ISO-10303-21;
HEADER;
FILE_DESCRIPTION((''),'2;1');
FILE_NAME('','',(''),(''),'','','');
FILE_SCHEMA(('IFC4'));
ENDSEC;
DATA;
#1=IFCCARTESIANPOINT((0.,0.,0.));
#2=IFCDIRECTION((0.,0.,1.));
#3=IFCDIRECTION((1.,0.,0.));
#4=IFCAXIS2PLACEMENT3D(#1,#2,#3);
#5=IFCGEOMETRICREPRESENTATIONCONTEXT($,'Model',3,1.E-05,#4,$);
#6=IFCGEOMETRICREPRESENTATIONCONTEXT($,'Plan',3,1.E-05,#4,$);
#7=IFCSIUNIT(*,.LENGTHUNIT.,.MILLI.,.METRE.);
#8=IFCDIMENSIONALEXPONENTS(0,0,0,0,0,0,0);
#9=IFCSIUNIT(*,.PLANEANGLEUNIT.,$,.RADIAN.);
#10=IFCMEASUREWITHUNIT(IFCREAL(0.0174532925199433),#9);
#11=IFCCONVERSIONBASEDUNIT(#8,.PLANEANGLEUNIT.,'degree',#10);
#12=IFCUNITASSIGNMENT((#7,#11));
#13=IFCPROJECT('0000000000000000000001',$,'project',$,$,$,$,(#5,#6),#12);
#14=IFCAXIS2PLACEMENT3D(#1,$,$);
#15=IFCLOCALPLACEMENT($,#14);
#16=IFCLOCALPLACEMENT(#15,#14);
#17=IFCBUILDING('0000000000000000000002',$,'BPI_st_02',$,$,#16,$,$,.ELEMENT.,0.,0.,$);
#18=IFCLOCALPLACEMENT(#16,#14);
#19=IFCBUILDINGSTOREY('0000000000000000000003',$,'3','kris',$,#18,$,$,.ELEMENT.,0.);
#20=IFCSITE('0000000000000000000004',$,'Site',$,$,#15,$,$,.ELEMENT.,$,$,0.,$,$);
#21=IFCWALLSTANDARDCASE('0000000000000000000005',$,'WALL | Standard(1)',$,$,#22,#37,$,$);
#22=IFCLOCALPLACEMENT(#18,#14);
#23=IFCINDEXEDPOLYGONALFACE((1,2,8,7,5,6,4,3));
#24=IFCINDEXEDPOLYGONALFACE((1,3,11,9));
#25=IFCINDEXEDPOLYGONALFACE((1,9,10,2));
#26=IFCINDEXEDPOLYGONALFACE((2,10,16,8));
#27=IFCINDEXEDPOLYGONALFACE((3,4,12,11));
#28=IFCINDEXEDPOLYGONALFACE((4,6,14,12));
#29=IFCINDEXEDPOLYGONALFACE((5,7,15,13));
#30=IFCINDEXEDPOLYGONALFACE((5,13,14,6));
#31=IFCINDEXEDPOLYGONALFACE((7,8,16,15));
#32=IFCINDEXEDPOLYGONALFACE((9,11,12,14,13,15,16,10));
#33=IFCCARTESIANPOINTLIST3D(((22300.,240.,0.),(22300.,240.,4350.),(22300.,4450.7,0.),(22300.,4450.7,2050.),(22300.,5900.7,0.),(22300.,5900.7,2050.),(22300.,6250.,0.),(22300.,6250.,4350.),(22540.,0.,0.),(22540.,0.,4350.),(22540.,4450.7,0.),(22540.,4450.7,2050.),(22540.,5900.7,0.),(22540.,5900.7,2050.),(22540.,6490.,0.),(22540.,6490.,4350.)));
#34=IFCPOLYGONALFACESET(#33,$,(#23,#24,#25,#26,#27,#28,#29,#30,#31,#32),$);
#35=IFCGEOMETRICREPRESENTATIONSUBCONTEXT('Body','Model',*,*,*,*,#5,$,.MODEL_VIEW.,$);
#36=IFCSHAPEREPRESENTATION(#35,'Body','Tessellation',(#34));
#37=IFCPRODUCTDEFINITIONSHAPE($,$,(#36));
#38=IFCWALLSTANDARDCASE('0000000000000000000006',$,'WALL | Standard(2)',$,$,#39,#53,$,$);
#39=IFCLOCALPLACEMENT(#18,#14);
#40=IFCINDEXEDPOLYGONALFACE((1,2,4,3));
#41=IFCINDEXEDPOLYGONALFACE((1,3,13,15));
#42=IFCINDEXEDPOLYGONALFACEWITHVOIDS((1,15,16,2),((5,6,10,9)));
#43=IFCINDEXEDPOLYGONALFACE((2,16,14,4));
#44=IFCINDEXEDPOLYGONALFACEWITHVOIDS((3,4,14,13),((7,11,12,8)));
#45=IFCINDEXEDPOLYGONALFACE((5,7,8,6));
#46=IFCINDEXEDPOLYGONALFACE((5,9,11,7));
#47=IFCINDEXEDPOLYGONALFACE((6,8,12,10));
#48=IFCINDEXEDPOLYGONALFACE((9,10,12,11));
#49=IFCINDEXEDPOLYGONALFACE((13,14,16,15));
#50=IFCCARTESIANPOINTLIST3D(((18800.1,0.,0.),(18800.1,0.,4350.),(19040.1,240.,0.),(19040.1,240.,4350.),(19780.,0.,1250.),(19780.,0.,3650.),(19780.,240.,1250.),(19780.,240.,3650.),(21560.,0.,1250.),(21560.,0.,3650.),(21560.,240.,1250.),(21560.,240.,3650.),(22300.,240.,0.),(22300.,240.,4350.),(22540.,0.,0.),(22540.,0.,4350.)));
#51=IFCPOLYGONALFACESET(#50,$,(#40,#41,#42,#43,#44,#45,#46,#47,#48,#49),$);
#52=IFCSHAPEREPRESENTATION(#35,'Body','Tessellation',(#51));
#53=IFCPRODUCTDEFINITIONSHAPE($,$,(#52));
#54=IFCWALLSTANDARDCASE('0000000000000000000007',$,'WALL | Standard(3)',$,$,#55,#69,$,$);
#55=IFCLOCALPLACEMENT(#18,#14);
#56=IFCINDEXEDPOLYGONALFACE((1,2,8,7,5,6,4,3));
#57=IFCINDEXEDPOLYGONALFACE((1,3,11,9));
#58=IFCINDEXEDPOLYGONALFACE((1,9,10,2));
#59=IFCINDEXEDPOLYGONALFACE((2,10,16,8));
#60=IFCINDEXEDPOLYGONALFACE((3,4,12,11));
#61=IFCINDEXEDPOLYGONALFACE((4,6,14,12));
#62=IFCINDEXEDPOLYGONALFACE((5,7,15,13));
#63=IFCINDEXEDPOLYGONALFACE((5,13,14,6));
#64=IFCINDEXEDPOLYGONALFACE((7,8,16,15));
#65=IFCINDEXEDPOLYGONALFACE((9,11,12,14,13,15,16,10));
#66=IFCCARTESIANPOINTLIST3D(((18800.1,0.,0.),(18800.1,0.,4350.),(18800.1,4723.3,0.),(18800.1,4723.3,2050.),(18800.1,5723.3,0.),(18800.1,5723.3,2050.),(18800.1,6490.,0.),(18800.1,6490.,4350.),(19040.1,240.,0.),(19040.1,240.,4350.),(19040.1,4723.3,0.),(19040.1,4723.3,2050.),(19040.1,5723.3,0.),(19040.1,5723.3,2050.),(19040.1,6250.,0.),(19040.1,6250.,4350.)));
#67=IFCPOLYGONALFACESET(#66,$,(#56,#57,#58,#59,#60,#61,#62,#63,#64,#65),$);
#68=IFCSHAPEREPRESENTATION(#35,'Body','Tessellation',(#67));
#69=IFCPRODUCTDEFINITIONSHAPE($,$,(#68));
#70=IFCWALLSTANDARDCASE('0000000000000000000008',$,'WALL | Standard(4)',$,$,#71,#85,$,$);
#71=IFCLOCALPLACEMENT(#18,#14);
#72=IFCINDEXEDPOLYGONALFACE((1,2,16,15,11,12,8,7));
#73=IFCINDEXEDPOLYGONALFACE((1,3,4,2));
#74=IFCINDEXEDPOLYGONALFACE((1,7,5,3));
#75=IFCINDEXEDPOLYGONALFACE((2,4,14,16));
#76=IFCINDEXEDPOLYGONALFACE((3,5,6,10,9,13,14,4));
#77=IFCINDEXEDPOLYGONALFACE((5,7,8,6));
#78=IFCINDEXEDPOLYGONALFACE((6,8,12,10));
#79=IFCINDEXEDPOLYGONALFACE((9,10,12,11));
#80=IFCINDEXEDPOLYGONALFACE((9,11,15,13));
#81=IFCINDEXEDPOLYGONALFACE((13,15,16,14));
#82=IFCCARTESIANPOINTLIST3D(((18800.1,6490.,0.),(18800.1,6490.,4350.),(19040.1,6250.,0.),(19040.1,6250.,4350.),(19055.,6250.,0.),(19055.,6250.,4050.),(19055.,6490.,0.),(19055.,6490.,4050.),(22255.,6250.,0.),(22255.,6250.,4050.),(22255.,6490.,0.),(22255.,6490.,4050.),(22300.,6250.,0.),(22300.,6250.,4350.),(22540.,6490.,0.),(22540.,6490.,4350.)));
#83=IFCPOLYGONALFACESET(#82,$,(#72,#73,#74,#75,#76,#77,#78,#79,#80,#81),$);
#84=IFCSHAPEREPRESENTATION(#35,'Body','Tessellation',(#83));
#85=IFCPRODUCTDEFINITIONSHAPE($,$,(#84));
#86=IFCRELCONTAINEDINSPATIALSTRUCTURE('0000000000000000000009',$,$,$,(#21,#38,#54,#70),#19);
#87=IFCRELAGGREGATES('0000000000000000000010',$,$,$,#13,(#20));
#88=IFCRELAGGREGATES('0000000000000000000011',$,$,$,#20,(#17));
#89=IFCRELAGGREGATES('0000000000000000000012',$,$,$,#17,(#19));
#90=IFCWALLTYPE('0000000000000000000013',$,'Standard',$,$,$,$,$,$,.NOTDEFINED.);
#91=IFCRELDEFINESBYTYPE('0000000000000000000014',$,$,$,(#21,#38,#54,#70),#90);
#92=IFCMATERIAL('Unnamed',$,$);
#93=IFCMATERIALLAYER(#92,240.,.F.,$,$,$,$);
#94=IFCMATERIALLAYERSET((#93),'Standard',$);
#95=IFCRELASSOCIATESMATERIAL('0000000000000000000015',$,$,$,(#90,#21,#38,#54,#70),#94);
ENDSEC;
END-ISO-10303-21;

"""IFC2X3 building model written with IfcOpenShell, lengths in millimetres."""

from ifc_helpers import new_model, entity, si_unit, converted_unit, frame, origin, origin_with_axes, origin_2d_with_axis, place, context, subcontext, project, spatial, polyline, segment, composite_curve, rectangle, outline, extrude, material, layer, layer_set, layer_usage, type_object, element, save


model = new_model("IFC2X3")

# Units and contexts
model_context = context("Model", 3, precision=1e-05, world=origin_with_axes())
plan_context = context("Plan", 3, precision=1e-05, world=origin_with_axes())
body_context = subcontext(model_context, "Body", "Model", "MODEL_VIEW")
ifc_project = project(units=[si_unit("LENGTHUNIT", "METRE", prefix="MILLI"), converted_unit("PLANEANGLEUNIT", "degree", entity("IfcReal", 0.0174532925199433), si_unit("PLANEANGLEUNIT", "RADIAN"), dimensions=[0, 0, 0, 0, 0, 0, 0])], contexts=[model_context, plan_context])

# Site, building, storey
site_placement = place(None, origin())
site = spatial("IfcSite", under=ifc_project, at=site_placement, Name="Site", CompositionType="ELEMENT", RefElevation=0.0)
building_placement = place(site_placement, origin())
building = spatial("IfcBuilding", under=site, at=building_placement, Name="BPI_st_02", CompositionType="ELEMENT", ElevationOfRefHeight=0.0, ElevationOfTerrain=0.0)
storey_placement = place(building_placement, origin())
storey = spatial("IfcBuildingStorey", under=building, at=storey_placement, Name="3", Description="kris", CompositionType="ELEMENT", Elevation=0.0)

# Shared definitions
ifc_material = material(Name="Unnamed")

# Walls, openings
ifc_layer_1 = layer(ifc_material, 240.0, ventilated=False)
ifc_layer_set_1 = layer_set([ifc_layer_1], Name="Standard")
ifc_layer_usage_1 = layer_usage(ifc_layer_set_1, "AXIS2", "POSITIVE", -120.0)
wall_type = type_object("IfcWallType", Name="Standard", PredefinedType="NOTDEFINED", material=ifc_layer_set_1)
wall_1_placement = place(storey_placement, frame((22420.0, 6370.0, 0.0), z_axis=(0.0, 0.0, 1.0), x_axis=(0.0, -1.0, 0.0)))
wall_1 = element("IfcWallStandardCase", 1, at=wall_1_placement, inside=storey, type_object=wall_type, material=ifc_layer_usage_1, Name="WALL | Standard(1)", context=body_context, shape_type="SweptSolid", body=[
    extrude(outline(composite_curve([segment(polyline([(-120.0, 120.0), (120.0, -120.0)]), True, "CONTINUOUS"), segment(polyline([(120.0, -120.0), (6130.0, -120.0)]), True, "CONTINUOUS"), segment(polyline([(6130.0, -120.0), (6370.0, 120.0)]), True, "CONTINUOUS"), segment(polyline([(6370.0, 120.0), (-120.0, 120.0)]), True, "CONTINUOUS")], self_intersect=False)), origin(), (0.0, 0.0, 1.0), 4350.0),
])
opening_1_placement = place(wall_1_placement, frame((469.3, 0.0, 0.0)))
element("IfcOpeningElement", 2, at=opening_1_placement, cuts=wall_1, context=body_context, shape_type="SweptSolid", body=[
    extrude(rectangle(XDim=1450.0, YDim=2050.0, at=origin_2d_with_axis()), frame((725.0, 120.0, 1025.0), z_axis=(0.0, -1.0, 0.0), x_axis=(1.0, 0.0, 0.0)), (0.0, 0.0, 1.0), 240.0),
])
ifc_layer_usage_2 = layer_usage(ifc_layer_set_1, "AXIS2", "POSITIVE", -120.0)
wall_2_placement = place(storey_placement, frame((22420.0, 120.0, 0.0), z_axis=(0.0, 0.0, 1.0), x_axis=(-1.0, 0.0, 0.0)))
wall_2 = element("IfcWallStandardCase", 3, at=wall_2_placement, inside=storey, type_object=wall_type, material=ifc_layer_usage_2, Name="WALL | Standard(2)", context=body_context, shape_type="SweptSolid", body=[
    extrude(outline(composite_curve([segment(polyline([(-120.0, 120.0), (120.0, -120.0)]), True, "CONTINUOUS"), segment(polyline([(120.0, -120.0), (3380.0, -120.0)]), True, "CONTINUOUS"), segment(polyline([(3380.0, -120.0), (3620.0, 120.0)]), True, "CONTINUOUS"), segment(polyline([(3620.0, 120.0), (-120.0, 120.0)]), True, "CONTINUOUS")], self_intersect=False)), origin(), (0.0, 0.0, 1.0), 4350.0),
])
opening_2_placement = place(wall_2_placement, frame((860.0, 0.0, 1250.0)))
element("IfcOpeningElement", 4, at=opening_2_placement, cuts=wall_2, context=body_context, shape_type="SweptSolid", body=[
    extrude(rectangle(XDim=1780.0, YDim=2400.0, at=origin_2d_with_axis()), frame((890.0, 120.0, 1200.0), z_axis=(0.0, -1.0, 0.0), x_axis=(1.0, 0.0, 0.0)), (0.0, 0.0, 1.0), 240.0),
])
ifc_layer_usage_3 = layer_usage(ifc_layer_set_1, "AXIS2", "POSITIVE", -120.0)
wall_3_placement = place(storey_placement, frame((18920.1, 6370.0, 0.0), z_axis=(0.0, 0.0, 1.0), x_axis=(0.0, -1.0, 0.0)))
wall_3 = element("IfcWallStandardCase", 5, at=wall_3_placement, inside=storey, type_object=wall_type, material=ifc_layer_usage_3, Name="WALL | Standard(3)", context=body_context, shape_type="SweptSolid", body=[
    extrude(outline(composite_curve([segment(polyline([(120.0, 120.0), (-120.0, -120.0)]), True, "CONTINUOUS"), segment(polyline([(-120.0, -120.0), (6370.0, -120.0)]), True, "CONTINUOUS"), segment(polyline([(6370.0, -120.0), (6130.0, 120.0)]), True, "CONTINUOUS"), segment(polyline([(6130.0, 120.0), (120.0, 120.0)]), True, "CONTINUOUS")], self_intersect=False)), origin(), (0.0, 0.0, 1.0), 4350.0),
])
opening_3_placement = place(wall_3_placement, frame((646.6, 0.0, 0.0)))
element("IfcOpeningElement", 6, at=opening_3_placement, cuts=wall_3, context=body_context, shape_type="SweptSolid", body=[
    extrude(rectangle(XDim=1000.0, YDim=2050.0, at=origin_2d_with_axis()), frame((500.0, 120.0, 1025.0), z_axis=(0.0, -1.0, 0.0), x_axis=(1.0, 0.0, 0.0)), (0.0, 0.0, 1.0), 240.0),
])
ifc_layer_usage_4 = layer_usage(ifc_layer_set_1, "AXIS2", "POSITIVE", -120.0)
wall_4_placement = place(storey_placement, frame((18920.1, 6370.0, 0.0)))
wall_4 = element("IfcWallStandardCase", 7, at=wall_4_placement, inside=storey, type_object=wall_type, material=ifc_layer_usage_4, Name="WALL | Standard(4)", context=body_context, shape_type="SweptSolid", body=[
    extrude(outline(composite_curve([segment(polyline([(-120.0, 120.0), (120.0, -120.0)]), True, "CONTINUOUS"), segment(polyline([(120.0, -120.0), (3380.0, -120.0)]), True, "CONTINUOUS"), segment(polyline([(3380.0, -120.0), (3620.0, 120.0)]), True, "CONTINUOUS"), segment(polyline([(3620.0, 120.0), (-120.0, 120.0)]), True, "CONTINUOUS")], self_intersect=False)), origin(), (0.0, 0.0, 1.0), 4350.0),
])
opening_4_placement = place(wall_4_placement, frame((135.0, 0.0, 0.0)))
element("IfcOpeningElement", 8, at=opening_4_placement, cuts=wall_4, context=body_context, shape_type="SweptSolid", body=[
    extrude(rectangle(XDim=3200.0, YDim=4050.0, at=origin_2d_with_axis()), frame((1600.0, 120.0, 2025.0), z_axis=(0.0, -1.0, 0.0), x_axis=(1.0, 0.0, 0.0)), (0.0, 0.0, 1.0), 240.0),
])

save(model, "model.ifc")
